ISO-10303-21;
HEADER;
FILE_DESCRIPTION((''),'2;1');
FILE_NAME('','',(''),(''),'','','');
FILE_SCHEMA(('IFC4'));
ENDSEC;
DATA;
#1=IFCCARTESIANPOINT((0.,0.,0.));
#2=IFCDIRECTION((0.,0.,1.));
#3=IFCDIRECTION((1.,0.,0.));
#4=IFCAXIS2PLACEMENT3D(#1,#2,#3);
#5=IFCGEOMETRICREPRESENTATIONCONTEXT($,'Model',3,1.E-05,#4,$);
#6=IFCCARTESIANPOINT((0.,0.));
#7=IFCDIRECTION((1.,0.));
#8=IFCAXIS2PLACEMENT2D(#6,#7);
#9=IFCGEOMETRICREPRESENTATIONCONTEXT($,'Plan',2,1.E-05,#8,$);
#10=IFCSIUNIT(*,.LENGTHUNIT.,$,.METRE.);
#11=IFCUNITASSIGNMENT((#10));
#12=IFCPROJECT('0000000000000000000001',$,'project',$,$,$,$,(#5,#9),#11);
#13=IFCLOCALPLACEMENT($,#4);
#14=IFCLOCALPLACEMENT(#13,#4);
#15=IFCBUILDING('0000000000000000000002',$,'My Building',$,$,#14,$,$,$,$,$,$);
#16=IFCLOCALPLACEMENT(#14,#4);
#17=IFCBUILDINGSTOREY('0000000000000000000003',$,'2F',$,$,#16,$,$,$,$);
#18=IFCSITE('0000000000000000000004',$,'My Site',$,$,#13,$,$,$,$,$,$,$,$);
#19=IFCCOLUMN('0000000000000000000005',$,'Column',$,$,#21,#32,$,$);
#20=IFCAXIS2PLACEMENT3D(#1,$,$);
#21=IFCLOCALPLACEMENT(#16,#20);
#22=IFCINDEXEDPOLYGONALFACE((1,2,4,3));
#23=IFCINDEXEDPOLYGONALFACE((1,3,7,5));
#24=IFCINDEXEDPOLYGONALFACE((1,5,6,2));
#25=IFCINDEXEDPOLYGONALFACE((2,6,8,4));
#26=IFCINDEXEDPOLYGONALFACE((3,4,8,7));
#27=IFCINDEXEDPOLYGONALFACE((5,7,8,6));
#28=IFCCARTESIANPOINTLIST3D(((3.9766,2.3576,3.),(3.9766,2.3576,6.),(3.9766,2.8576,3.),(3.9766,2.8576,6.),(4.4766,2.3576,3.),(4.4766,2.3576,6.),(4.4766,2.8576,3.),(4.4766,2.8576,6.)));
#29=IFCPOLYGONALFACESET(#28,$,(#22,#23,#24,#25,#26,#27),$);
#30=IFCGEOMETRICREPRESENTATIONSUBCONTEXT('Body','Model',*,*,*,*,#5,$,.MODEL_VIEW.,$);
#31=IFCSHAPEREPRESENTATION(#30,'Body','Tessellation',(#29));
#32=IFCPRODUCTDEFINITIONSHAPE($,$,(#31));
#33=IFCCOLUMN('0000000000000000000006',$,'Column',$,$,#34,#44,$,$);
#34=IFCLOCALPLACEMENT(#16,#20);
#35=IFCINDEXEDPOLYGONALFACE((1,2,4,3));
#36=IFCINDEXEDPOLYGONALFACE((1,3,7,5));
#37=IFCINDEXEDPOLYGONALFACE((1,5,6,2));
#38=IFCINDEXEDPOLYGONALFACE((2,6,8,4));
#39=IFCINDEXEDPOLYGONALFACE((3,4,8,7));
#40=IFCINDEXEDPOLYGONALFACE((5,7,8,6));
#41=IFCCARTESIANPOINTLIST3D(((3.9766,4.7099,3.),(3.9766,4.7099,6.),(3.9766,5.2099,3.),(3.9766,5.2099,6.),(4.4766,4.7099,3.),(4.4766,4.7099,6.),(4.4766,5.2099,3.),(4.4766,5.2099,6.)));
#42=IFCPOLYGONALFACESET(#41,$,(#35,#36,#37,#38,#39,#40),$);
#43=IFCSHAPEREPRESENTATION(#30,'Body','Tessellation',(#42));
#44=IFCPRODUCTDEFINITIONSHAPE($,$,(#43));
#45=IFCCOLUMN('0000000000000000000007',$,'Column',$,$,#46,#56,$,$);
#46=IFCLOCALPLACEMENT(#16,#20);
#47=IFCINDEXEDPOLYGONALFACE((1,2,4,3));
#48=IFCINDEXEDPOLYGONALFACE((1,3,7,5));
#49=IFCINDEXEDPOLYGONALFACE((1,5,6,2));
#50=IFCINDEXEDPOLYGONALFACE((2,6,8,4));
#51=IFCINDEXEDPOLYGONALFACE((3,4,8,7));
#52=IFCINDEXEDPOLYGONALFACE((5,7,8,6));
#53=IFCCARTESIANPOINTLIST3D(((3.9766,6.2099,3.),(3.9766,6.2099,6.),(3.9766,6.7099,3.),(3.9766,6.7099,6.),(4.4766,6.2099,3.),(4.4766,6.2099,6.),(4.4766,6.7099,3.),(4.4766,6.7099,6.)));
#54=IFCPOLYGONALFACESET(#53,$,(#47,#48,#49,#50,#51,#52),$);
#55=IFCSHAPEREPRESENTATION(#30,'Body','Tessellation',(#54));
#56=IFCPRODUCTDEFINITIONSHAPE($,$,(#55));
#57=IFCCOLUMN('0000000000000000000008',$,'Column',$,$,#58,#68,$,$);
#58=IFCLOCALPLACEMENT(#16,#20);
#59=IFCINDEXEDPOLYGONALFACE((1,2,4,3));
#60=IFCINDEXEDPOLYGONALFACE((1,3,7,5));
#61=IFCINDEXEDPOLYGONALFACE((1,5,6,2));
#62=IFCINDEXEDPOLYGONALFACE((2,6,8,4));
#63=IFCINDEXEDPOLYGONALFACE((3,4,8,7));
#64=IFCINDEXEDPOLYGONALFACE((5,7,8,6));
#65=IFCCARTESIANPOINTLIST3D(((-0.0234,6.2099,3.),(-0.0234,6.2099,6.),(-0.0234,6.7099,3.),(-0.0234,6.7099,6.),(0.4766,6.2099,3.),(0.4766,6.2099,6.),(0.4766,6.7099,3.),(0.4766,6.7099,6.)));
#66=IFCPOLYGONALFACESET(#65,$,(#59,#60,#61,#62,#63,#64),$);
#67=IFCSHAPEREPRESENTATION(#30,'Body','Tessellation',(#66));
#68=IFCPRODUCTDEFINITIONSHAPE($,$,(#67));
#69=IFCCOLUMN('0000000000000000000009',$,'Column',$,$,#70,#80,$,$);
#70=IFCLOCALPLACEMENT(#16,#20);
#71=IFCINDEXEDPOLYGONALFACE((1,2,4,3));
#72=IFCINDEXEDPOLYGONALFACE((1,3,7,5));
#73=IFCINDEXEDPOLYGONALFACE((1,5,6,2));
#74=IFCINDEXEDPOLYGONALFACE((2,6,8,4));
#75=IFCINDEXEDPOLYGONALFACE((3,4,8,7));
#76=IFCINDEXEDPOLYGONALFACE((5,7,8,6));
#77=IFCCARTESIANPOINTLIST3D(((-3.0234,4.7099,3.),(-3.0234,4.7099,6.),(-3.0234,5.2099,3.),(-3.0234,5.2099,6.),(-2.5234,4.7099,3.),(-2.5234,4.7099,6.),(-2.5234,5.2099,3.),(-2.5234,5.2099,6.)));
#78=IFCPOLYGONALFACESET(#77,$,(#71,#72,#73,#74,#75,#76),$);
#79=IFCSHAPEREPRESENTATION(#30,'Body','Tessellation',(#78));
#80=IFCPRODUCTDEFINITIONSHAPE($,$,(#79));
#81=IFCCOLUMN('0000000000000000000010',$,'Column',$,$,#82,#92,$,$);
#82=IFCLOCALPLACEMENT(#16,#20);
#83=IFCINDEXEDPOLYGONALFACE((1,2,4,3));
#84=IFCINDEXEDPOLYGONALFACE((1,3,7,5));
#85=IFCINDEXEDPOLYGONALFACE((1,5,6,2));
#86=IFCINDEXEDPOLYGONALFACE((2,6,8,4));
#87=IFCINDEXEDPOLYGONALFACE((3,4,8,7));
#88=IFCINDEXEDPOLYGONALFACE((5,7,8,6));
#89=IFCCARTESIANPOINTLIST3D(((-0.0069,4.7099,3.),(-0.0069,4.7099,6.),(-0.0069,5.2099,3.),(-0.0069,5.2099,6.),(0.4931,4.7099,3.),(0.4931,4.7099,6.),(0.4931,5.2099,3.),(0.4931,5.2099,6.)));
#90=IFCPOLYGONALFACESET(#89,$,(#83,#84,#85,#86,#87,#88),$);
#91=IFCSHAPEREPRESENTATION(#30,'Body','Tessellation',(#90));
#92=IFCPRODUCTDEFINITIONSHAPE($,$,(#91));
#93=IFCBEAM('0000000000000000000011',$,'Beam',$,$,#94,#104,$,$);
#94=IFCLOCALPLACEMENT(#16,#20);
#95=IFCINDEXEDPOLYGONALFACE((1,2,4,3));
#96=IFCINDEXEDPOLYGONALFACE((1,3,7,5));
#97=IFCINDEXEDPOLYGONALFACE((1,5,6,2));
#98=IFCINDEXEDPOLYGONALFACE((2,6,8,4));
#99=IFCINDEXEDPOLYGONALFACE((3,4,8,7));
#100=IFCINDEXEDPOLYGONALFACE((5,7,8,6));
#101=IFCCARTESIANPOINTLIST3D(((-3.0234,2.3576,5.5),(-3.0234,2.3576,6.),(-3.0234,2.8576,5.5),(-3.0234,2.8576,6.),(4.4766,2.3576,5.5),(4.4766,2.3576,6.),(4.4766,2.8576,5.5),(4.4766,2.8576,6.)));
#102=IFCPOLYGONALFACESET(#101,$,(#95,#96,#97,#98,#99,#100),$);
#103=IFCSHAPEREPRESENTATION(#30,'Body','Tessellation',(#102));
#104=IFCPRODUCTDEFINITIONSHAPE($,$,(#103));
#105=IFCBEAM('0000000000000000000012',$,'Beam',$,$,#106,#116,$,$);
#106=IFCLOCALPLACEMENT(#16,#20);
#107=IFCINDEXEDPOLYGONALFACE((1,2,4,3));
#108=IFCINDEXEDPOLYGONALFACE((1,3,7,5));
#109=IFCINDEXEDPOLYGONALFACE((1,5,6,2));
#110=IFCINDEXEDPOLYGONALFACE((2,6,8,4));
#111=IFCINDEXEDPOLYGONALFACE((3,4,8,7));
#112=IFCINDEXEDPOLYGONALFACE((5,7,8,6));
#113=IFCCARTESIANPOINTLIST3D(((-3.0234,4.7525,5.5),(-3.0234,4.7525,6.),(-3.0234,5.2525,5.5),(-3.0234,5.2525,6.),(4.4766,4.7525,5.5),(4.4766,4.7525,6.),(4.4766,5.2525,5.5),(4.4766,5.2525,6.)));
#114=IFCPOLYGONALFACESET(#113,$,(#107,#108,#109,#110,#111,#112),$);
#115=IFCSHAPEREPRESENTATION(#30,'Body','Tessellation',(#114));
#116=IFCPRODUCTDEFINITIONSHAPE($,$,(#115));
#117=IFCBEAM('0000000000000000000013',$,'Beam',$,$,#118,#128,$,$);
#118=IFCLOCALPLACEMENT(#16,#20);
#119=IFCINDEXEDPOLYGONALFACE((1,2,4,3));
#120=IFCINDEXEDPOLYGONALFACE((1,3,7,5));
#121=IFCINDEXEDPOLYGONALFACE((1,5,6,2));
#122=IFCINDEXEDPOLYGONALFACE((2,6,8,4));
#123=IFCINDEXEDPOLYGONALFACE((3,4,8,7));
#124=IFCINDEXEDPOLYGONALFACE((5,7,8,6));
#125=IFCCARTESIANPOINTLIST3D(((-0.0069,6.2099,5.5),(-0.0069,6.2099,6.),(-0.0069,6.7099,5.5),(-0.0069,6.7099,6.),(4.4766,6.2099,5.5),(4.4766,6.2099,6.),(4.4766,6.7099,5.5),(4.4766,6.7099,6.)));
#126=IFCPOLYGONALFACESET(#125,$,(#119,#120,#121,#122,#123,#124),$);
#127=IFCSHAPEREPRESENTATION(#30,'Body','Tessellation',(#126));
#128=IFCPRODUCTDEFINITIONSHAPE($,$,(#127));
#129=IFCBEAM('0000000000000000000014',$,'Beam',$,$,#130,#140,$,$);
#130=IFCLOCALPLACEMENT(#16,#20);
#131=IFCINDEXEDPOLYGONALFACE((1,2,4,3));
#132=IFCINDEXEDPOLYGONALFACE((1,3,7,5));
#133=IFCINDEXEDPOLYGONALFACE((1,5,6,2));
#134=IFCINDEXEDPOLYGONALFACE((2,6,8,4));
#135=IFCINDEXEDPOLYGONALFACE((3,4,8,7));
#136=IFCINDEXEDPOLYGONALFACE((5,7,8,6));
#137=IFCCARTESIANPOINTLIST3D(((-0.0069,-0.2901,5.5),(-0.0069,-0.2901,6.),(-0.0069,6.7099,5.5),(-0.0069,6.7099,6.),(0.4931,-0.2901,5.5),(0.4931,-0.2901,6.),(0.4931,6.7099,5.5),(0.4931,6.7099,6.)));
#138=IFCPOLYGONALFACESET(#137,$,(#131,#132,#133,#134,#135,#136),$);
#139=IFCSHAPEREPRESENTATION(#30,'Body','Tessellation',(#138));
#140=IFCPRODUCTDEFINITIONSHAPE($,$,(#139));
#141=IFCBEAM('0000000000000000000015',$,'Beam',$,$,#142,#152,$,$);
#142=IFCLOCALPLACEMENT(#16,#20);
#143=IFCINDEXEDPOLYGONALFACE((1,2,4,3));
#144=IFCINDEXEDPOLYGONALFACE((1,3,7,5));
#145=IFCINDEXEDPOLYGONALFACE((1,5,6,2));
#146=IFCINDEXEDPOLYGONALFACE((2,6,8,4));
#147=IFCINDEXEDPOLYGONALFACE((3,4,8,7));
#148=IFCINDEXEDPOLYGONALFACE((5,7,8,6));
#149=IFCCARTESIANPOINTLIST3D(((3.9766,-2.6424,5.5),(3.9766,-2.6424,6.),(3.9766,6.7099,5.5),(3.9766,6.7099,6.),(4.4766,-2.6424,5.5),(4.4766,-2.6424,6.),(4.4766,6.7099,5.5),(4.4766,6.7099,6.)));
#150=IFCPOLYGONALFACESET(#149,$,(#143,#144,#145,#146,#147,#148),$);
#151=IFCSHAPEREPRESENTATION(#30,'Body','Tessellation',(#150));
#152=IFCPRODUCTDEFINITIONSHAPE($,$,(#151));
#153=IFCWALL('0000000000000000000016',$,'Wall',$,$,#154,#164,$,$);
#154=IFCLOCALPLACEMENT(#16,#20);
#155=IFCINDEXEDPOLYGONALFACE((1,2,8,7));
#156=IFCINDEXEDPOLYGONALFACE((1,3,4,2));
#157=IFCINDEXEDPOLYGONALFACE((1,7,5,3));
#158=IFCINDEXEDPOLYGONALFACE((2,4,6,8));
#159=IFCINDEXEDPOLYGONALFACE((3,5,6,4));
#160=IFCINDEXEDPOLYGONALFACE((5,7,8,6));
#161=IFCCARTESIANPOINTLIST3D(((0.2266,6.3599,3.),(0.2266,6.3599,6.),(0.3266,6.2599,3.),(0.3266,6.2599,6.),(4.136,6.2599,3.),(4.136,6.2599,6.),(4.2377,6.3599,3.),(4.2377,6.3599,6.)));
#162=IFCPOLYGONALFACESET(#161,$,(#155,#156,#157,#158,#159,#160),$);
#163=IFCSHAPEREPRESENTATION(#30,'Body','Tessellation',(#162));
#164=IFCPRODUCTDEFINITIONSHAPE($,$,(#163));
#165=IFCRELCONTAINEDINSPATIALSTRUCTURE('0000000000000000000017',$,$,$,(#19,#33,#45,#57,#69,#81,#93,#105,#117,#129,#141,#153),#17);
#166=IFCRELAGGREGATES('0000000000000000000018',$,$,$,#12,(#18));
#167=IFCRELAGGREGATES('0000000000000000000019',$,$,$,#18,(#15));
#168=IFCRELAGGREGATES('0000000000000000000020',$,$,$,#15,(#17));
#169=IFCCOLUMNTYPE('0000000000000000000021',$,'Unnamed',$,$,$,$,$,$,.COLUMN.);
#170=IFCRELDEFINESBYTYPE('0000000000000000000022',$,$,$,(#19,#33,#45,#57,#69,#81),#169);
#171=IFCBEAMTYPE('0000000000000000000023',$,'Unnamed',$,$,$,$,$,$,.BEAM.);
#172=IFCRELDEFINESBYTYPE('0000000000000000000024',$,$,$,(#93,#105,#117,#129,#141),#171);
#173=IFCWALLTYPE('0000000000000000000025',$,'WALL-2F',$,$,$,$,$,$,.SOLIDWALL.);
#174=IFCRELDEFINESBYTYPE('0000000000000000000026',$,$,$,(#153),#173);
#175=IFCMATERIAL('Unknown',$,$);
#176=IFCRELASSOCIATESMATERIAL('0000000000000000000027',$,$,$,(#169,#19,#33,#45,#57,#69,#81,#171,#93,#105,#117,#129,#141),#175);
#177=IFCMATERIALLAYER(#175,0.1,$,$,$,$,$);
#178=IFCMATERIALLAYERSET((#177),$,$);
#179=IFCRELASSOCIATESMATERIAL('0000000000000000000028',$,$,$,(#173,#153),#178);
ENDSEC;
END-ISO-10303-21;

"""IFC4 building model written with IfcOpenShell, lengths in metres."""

from ifc_helpers import new_model, si_unit, frame, origin_with_axes, origin_2d_with_axis, place, context, subcontext, project, spatial, line, indexed_curve, rectangle, outline, extrude, material, layer, layer_set, layer_usage, material_profile, profile_set, profile_usage, type_object, element, save


model = new_model("IFC4")

# Units and contexts
model_context = context("Model", 3, precision=1e-05, world=origin_with_axes())
plan_context = context("Plan", 2, precision=1e-05, world=origin_2d_with_axis())
body_context_1 = subcontext(model_context, "Body", "Model", "MODEL_VIEW")
ifc_project = project(units=[si_unit("LENGTHUNIT", "METRE")], contexts=[model_context, plan_context])

# Site, building, storey
site_placement = place(None, origin_with_axes())
site = spatial("IfcSite", under=ifc_project, at=site_placement, Name="My Site")
building_placement = place(site_placement, origin_with_axes())
building = spatial("IfcBuilding", under=site, at=building_placement, Name="My Building")
storey_placement = place(building_placement, origin_with_axes())
storey = spatial("IfcBuildingStorey", under=building, at=storey_placement, Name="2F")

# Columns
ifc_material = material(Name="Unknown")
ifc_material_profile_1 = material_profile(ifc_material, rectangle(XDim=0.5, YDim=0.5))
ifc_profile_set_1 = profile_set([ifc_material_profile_1])
ifc_profile_usage_1 = profile_usage(ifc_profile_set_1, cardinal=7)
column_type = type_object("IfcColumnType", Name="Unnamed", PredefinedType="COLUMN", material=ifc_profile_set_1)
column_1_placement = place(storey_placement, frame((4.4766, 2.8576, 3.0), z_axis=(0.0, 0.0, 1.0), x_axis=(1.0, 0.0, 0.0)))
element("IfcColumn", 1, at=column_1_placement, inside=storey, type_object=column_type, material=ifc_profile_usage_1, Name="Column", context=body_context_1, shape_type="SweptSolid", body=[
    extrude(rectangle(XDim=0.5, YDim=0.5), frame((-0.25, -0.25, 0.0), z_axis=(0.0, 0.0, 1.0), x_axis=(1.0, 0.0, 0.0)), (0.0, 0.0, 1.0), 3.0),
])
ifc_profile_usage_2 = profile_usage(ifc_profile_set_1, cardinal=7)
column_2_placement = place(storey_placement, frame((4.4766, 5.2099, 3.0), z_axis=(0.0, 0.0, 1.0), x_axis=(1.0, 0.0, 0.0)))
element("IfcColumn", 2, at=column_2_placement, inside=storey, type_object=column_type, material=ifc_profile_usage_2, Name="Column", context=body_context_1, shape_type="SweptSolid", body=[
    extrude(rectangle(XDim=0.5, YDim=0.5), frame((-0.25, -0.25, 0.0), z_axis=(0.0, 0.0, 1.0), x_axis=(1.0, 0.0, 0.0)), (0.0, 0.0, 1.0), 3.0),
])
ifc_profile_usage_3 = profile_usage(ifc_profile_set_1, cardinal=7)
column_3_placement = place(storey_placement, frame((4.4766, 6.7099, 3.0), z_axis=(0.0, 0.0, 1.0), x_axis=(1.0, 0.0, 0.0)))
element("IfcColumn", 3, at=column_3_placement, inside=storey, type_object=column_type, material=ifc_profile_usage_3, Name="Column", context=body_context_1, shape_type="SweptSolid", body=[
    extrude(rectangle(XDim=0.5, YDim=0.5), frame((-0.25, -0.25, 0.0), z_axis=(0.0, 0.0, 1.0), x_axis=(1.0, 0.0, 0.0)), (0.0, 0.0, 1.0), 3.0),
])
ifc_profile_usage_4 = profile_usage(ifc_profile_set_1, cardinal=7)
column_4_placement = place(storey_placement, frame((0.4766, 6.7099, 3.0), z_axis=(0.0, 0.0, 1.0), x_axis=(1.0, 0.0, 0.0)))
element("IfcColumn", 4, at=column_4_placement, inside=storey, type_object=column_type, material=ifc_profile_usage_4, Name="Column", context=body_context_1, shape_type="SweptSolid", body=[
    extrude(rectangle(XDim=0.5, YDim=0.5), frame((-0.25, -0.25, 0.0), z_axis=(0.0, 0.0, 1.0), x_axis=(1.0, 0.0, 0.0)), (0.0, 0.0, 1.0), 3.0),
])
ifc_profile_usage_5 = profile_usage(ifc_profile_set_1, cardinal=7)
column_5_placement = place(storey_placement, frame((-2.5234, 5.2099, 3.0), z_axis=(0.0, 0.0, 1.0), x_axis=(1.0, 0.0, 0.0)))
element("IfcColumn", 5, at=column_5_placement, inside=storey, type_object=column_type, material=ifc_profile_usage_5, Name="Column", context=body_context_1, shape_type="SweptSolid", body=[
    extrude(rectangle(XDim=0.5, YDim=0.5), frame((-0.25, -0.25, 0.0), z_axis=(0.0, 0.0, 1.0), x_axis=(1.0, 0.0, 0.0)), (0.0, 0.0, 1.0), 3.0),
])
ifc_profile_usage_6 = profile_usage(ifc_profile_set_1, cardinal=7)
column_6_placement = place(storey_placement, frame((0.4931, 5.2099, 3.0), z_axis=(0.0, 0.0, 1.0), x_axis=(1.0, 0.0, 0.0)))
element("IfcColumn", 6, at=column_6_placement, inside=storey, type_object=column_type, material=ifc_profile_usage_6, Name="Column", context=body_context_1, shape_type="SweptSolid", body=[
    extrude(rectangle(XDim=0.5, YDim=0.5), frame((-0.25, -0.25, 0.0), z_axis=(0.0, 0.0, 1.0), x_axis=(1.0, 0.0, 0.0)), (0.0, 0.0, 1.0), 3.0),
])

# Beams
ifc_material_profile_2 = material_profile(ifc_material, rectangle(XDim=0.5, YDim=0.5))
ifc_profile_set_2 = profile_set([ifc_material_profile_2])
ifc_profile_usage_7 = profile_usage(ifc_profile_set_2, cardinal=7)
beam_type = type_object("IfcBeamType", Name="Unnamed", PredefinedType="BEAM", material=ifc_profile_set_2)
beam_1_placement = place(storey_placement, frame((-3.0234, 2.8576, 6.0), z_axis=(1.0, 0.0, 0.0), x_axis=(0.0, 1.0, 0.0)))
element("IfcBeam", 7, at=beam_1_placement, inside=storey, type_object=beam_type, material=ifc_profile_usage_7, Name="Beam", context=body_context_1, shape_type="SweptSolid", body=[
    extrude(rectangle(XDim=0.5, YDim=0.5), frame((-0.25, -0.25, 0.0), z_axis=(0.0, 0.0, 1.0), x_axis=(1.0, 0.0, 0.0)), (0.0, 0.0, 1.0), 7.5),
])
ifc_profile_usage_8 = profile_usage(ifc_profile_set_2, cardinal=7)
beam_2_placement = place(storey_placement, frame((-3.0234, 5.2525, 6.0), z_axis=(1.0, 0.0, 0.0), x_axis=(0.0, 1.0, 0.0)))
element("IfcBeam", 8, at=beam_2_placement, inside=storey, type_object=beam_type, material=ifc_profile_usage_8, Name="Beam", context=body_context_1, shape_type="SweptSolid", body=[
    extrude(rectangle(XDim=0.5, YDim=0.5), frame((-0.25, -0.25, 0.0), z_axis=(0.0, 0.0, 1.0), x_axis=(1.0, 0.0, 0.0)), (0.0, 0.0, 1.0), 7.5),
])
ifc_profile_usage_9 = profile_usage(ifc_profile_set_2, cardinal=7)
beam_3_placement = place(storey_placement, frame((-0.0069, 6.7099, 6.0), z_axis=(1.0, -0.000001, 0.000001), x_axis=(0.000001, 1.0, 0.0)))
element("IfcBeam", 9, at=beam_3_placement, inside=storey, type_object=beam_type, material=ifc_profile_usage_9, Name="Beam", context=body_context_1, shape_type="SweptSolid", body=[
    extrude(rectangle(XDim=0.5, YDim=0.5), frame((-0.25, -0.25, 0.0), z_axis=(0.0, 0.0, 1.0), x_axis=(1.0, 0.0, 0.0)), (0.0, 0.0, 1.0), 4.4835),
])
ifc_profile_usage_10 = profile_usage(ifc_profile_set_2, cardinal=7)
beam_4_placement = place(storey_placement, frame((0.4931, 6.7099, 6.0), z_axis=(0.0, -1.0, 0.0), x_axis=(1.0, 0.0, 0.0)))
element("IfcBeam", 10, at=beam_4_placement, inside=storey, type_object=beam_type, material=ifc_profile_usage_10, Name="Beam", context=body_context_1, shape_type="SweptSolid", body=[
    extrude(rectangle(XDim=0.5, YDim=0.5), frame((-0.25, -0.25, 0.0), z_axis=(0.0, 0.0, 1.0), x_axis=(1.0, 0.0, 0.0)), (0.0, 0.0, 1.0), 7.0),
])
ifc_profile_usage_11 = profile_usage(ifc_profile_set_2, cardinal=7)
beam_5_placement = place(storey_placement, frame((4.4766, 6.7099, 6.0), z_axis=(0.0, -1.0, 0.0), x_axis=(1.0, 0.0, 0.0)))
element("IfcBeam", 11, at=beam_5_placement, inside=storey, type_object=beam_type, material=ifc_profile_usage_11, Name="Beam", context=body_context_1, shape_type="SweptSolid", body=[
    extrude(rectangle(XDim=0.5, YDim=0.5), frame((-0.25, -0.25, 0.0), z_axis=(0.0, 0.0, 1.0), x_axis=(1.0, 0.0, 0.0)), (0.0, 0.0, 1.0), 9.3523),
])

# Wall
ifc_layer = layer(ifc_material, 0.1)
ifc_layer_set = layer_set([ifc_layer])
ifc_layer_usage_1 = layer_usage(ifc_layer_set, "AXIS2", "POSITIVE", 0.0)
wall_type = type_object("IfcWallType", Name="WALL-2F", PredefinedType="SOLIDWALL", material=ifc_layer_set)
wall_1_placement = place(storey_placement, frame((4.2377, 6.3599, 3.0), z_axis=(0.0, 0.0, 1.0), x_axis=(-1.0, 0.0, 0.0)))
element("IfcWall", 12, at=wall_1_placement, inside=storey, type_object=wall_type, material=ifc_layer_usage_1, Name="Wall", context=body_context_1, shape_type="SweptSolid", body=[
    extrude(outline(indexed_curve([(0.0, 0.0), (0.1017, 0.1), (3.9111, 0.1), (4.0111, 0.0)], segments=[line(1, 2, 3, 4, 1)])), origin_with_axes(), (0.0, 0.0, 1.0), 3.0),
])

save(model, "model.ifc")
